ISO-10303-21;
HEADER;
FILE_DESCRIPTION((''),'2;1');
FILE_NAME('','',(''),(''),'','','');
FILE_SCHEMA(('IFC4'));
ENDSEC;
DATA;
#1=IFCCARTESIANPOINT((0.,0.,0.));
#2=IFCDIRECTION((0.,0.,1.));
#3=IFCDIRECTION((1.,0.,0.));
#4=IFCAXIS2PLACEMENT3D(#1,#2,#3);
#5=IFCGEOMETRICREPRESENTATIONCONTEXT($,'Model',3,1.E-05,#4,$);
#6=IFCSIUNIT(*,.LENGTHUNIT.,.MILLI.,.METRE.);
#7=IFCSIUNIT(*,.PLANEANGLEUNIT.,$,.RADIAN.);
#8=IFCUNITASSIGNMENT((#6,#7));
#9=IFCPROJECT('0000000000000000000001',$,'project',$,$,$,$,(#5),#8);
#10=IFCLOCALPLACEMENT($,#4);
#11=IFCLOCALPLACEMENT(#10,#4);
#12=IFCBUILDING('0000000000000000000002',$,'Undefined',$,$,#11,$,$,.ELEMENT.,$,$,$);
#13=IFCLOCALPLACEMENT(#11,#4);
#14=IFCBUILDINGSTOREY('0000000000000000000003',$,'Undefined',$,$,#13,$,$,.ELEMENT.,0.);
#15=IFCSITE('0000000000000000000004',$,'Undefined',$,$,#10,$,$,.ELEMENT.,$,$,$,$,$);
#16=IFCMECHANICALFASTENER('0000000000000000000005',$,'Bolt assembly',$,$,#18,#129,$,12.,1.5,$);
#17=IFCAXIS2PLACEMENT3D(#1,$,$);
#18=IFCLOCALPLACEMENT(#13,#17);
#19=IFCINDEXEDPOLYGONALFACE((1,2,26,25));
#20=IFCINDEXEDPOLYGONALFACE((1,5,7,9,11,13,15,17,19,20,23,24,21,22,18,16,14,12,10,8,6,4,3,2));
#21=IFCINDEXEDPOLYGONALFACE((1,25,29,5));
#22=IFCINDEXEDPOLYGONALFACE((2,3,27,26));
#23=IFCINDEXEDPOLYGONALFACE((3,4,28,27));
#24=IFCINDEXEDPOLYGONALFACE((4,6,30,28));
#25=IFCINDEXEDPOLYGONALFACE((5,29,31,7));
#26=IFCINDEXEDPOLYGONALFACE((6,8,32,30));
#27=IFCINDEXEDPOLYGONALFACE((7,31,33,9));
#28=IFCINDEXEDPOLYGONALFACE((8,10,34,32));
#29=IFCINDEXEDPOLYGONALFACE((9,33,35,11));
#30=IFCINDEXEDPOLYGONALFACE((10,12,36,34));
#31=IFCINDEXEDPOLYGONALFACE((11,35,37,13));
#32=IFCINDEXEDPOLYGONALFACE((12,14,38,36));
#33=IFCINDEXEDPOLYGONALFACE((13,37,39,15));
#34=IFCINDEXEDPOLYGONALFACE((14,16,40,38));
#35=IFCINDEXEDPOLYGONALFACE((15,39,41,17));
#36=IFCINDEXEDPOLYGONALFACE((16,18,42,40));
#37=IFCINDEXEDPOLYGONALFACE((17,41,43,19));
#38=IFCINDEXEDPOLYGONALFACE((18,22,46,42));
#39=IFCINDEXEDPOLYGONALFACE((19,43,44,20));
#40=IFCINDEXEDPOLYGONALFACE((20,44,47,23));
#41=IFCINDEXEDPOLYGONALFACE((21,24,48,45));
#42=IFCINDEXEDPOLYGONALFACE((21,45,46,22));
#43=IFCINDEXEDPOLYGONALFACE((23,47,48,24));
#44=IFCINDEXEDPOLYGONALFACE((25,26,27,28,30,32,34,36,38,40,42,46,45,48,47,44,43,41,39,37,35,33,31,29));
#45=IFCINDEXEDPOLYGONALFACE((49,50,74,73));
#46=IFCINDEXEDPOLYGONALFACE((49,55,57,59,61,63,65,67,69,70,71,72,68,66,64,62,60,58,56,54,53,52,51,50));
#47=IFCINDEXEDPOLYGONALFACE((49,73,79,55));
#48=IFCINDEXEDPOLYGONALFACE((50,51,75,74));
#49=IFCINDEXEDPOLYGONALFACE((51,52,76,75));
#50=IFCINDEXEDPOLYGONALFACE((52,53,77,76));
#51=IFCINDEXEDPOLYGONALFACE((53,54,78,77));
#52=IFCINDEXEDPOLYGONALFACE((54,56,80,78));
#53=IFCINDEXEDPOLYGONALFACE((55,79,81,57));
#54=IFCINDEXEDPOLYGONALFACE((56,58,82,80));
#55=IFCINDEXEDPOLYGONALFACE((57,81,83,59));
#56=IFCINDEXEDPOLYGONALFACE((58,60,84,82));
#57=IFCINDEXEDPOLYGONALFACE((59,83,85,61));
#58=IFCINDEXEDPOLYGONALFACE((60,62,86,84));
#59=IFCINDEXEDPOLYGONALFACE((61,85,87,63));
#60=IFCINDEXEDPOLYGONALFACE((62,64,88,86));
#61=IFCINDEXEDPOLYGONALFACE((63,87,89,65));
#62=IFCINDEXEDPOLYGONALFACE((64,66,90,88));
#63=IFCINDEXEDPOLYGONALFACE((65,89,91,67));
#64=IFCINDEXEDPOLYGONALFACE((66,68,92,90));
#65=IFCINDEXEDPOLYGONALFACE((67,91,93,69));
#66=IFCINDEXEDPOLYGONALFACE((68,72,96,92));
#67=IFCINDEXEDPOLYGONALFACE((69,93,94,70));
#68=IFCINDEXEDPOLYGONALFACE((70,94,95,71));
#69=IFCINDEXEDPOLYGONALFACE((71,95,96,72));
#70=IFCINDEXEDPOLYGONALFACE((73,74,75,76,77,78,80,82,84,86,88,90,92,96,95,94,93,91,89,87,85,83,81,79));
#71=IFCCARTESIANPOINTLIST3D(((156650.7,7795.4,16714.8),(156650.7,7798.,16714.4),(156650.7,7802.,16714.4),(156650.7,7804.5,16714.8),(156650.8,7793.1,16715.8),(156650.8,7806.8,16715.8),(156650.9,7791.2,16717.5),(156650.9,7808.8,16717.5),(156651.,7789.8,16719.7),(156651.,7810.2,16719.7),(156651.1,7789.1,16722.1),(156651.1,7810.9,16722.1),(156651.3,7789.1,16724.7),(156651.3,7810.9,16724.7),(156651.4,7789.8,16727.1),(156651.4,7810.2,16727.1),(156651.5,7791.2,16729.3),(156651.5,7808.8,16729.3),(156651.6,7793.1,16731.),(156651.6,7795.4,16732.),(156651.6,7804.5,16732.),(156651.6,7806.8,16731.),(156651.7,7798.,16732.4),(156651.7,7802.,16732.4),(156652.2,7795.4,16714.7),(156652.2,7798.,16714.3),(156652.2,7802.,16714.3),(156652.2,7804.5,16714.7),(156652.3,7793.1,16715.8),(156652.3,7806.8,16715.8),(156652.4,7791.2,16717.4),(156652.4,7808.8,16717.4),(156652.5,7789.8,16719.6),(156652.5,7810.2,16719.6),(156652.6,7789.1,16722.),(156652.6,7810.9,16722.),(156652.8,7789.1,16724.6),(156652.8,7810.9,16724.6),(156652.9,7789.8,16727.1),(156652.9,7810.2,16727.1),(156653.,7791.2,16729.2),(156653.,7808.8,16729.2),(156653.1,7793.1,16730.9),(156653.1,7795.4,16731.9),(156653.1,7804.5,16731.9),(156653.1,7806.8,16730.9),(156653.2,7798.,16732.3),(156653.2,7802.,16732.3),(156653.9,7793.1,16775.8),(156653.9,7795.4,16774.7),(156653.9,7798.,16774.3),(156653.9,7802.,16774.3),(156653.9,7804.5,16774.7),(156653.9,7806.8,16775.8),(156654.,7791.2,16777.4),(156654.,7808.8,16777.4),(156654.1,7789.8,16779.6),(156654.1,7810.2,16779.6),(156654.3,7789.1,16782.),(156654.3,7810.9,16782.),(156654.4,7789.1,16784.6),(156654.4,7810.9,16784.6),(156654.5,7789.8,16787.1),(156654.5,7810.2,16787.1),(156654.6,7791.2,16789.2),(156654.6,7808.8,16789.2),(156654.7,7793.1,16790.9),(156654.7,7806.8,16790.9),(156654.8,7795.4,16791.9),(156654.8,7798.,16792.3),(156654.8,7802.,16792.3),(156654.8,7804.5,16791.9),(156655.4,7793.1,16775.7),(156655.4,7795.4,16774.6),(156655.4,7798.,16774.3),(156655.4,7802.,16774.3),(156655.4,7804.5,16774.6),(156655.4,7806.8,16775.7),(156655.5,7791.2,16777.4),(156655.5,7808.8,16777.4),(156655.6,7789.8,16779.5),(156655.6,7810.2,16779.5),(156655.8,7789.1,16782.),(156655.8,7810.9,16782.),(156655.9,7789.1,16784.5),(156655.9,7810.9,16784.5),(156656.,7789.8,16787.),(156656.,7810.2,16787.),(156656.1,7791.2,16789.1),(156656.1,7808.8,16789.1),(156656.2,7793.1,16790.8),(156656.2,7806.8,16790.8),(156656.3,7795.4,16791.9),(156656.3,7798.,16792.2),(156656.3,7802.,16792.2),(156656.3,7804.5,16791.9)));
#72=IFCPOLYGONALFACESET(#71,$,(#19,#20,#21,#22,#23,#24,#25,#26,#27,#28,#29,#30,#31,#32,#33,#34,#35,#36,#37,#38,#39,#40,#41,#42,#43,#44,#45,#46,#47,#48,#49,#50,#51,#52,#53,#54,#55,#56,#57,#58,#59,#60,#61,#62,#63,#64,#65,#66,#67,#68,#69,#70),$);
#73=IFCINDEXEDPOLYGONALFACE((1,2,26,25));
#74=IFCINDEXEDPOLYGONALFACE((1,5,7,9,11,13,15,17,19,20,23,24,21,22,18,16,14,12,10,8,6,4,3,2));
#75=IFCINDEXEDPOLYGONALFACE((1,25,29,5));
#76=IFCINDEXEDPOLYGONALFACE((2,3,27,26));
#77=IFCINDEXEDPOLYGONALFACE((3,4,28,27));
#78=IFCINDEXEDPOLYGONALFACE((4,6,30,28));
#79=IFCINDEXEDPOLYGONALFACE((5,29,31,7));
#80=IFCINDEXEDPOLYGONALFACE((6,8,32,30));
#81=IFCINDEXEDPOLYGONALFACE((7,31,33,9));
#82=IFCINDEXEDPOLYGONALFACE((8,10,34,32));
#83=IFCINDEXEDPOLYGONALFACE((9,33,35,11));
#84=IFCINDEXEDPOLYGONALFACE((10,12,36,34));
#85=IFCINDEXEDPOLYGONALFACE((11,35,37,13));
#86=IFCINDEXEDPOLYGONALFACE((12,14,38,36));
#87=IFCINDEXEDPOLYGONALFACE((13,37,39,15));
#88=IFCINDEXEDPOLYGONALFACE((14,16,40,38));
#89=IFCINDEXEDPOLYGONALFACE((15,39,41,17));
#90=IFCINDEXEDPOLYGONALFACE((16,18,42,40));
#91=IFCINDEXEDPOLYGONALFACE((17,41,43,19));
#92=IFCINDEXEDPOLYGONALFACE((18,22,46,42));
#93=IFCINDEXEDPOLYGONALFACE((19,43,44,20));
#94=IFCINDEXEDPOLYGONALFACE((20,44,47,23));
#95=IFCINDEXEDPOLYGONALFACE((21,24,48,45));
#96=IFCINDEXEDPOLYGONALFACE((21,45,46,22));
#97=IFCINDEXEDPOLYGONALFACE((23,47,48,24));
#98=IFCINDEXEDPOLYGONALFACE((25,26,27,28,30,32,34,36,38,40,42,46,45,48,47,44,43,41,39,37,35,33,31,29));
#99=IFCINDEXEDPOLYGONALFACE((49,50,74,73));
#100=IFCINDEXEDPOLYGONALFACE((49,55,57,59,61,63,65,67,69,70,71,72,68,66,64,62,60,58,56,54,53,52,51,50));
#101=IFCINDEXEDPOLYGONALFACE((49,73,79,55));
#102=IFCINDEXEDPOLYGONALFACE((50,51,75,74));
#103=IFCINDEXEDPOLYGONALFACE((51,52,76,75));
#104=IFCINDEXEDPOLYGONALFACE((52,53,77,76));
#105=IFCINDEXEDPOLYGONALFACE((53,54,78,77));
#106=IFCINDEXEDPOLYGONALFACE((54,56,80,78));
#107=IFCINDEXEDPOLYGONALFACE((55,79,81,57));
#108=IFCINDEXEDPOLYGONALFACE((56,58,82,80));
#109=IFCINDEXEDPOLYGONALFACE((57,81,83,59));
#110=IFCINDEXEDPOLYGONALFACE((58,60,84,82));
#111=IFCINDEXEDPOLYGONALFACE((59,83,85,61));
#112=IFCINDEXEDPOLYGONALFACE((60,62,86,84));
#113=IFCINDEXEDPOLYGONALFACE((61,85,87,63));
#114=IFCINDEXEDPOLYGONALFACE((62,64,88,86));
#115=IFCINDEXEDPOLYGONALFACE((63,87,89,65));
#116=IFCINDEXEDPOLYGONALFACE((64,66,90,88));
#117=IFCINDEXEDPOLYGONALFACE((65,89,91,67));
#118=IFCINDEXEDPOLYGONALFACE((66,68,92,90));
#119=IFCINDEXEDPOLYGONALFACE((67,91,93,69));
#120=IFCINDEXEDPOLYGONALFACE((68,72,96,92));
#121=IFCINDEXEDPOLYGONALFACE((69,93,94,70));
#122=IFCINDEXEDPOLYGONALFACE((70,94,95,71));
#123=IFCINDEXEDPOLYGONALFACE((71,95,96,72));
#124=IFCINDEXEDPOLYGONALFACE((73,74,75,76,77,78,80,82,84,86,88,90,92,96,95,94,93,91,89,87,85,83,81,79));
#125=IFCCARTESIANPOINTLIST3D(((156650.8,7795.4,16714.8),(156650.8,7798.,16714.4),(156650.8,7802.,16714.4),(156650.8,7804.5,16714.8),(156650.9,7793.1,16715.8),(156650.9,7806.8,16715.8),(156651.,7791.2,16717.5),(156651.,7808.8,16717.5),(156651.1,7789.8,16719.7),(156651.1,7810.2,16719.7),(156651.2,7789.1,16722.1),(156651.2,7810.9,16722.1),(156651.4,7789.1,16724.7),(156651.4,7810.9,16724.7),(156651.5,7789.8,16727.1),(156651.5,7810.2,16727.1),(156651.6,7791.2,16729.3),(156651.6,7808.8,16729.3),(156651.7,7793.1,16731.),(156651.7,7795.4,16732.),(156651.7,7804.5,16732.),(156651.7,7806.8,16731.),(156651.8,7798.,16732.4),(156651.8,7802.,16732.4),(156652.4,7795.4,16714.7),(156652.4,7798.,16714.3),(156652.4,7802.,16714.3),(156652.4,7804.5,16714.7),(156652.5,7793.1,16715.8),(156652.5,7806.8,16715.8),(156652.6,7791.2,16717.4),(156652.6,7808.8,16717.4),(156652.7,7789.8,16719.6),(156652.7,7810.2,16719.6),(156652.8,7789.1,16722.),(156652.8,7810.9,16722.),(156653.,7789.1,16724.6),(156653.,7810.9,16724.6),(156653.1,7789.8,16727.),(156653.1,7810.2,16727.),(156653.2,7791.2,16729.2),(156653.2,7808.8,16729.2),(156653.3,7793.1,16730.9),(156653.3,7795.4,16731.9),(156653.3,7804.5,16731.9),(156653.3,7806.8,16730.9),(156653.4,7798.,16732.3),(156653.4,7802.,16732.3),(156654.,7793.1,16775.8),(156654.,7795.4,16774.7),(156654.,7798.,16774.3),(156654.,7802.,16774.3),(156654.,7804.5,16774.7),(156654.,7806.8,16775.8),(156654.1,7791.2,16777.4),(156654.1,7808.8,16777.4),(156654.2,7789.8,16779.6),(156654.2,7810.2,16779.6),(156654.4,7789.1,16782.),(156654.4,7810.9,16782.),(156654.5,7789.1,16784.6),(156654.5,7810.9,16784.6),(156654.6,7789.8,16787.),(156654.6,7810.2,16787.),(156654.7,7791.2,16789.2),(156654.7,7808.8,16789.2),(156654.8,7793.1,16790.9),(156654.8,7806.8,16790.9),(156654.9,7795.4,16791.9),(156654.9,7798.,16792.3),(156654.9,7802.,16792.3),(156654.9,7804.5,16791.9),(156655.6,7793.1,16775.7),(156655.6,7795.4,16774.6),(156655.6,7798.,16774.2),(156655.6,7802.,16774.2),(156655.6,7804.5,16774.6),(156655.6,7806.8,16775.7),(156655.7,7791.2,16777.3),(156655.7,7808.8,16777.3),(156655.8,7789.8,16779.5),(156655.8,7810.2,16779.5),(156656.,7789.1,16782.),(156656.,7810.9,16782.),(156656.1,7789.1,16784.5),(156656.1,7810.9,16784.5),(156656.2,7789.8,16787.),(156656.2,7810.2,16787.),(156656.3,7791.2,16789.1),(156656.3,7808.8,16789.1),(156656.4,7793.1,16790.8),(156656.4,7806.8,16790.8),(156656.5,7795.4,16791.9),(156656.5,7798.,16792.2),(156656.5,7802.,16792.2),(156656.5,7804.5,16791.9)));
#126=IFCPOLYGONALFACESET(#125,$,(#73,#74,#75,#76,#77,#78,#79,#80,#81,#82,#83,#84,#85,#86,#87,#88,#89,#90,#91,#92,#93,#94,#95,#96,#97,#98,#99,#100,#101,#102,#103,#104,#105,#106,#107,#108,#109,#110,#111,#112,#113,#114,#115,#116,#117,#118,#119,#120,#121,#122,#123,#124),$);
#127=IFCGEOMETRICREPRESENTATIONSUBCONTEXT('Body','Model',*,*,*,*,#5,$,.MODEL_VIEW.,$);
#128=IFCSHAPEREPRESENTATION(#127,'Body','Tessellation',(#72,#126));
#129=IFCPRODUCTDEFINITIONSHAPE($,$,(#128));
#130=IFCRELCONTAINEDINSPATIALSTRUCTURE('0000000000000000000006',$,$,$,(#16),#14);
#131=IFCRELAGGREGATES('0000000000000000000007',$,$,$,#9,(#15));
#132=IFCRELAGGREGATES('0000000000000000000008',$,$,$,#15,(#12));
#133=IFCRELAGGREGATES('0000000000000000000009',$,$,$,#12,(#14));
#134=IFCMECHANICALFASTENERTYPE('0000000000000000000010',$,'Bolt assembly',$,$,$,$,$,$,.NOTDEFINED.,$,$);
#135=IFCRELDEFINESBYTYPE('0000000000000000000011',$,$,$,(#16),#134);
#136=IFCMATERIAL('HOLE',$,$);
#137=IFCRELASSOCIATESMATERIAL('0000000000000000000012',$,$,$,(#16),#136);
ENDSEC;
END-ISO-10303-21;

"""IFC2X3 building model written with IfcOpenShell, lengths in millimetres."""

from ifc_helpers import new_model, entity, si_unit, frame, origin_with_axes, place, context, subcontext, project, spatial, source, transform, mapped, material, type_object, element, save


model = new_model("IFC2X3")

# Units and contexts
model_context = context("Model", 3, precision=1e-05, world=origin_with_axes())
body_context = subcontext(model_context, "Body", "Model", "MODEL_VIEW")
ifc_project = project(units=[si_unit("LENGTHUNIT", "METRE", prefix="MILLI"), si_unit("PLANEANGLEUNIT", "RADIAN")], contexts=[model_context])

# Site, building, storey
site_placement = place(None, origin_with_axes())
site = spatial("IfcSite", under=ifc_project, at=site_placement, Name="Undefined", CompositionType="ELEMENT")
building_placement = place(site_placement, origin_with_axes())
building = spatial("IfcBuilding", under=site, at=building_placement, Name="Undefined", CompositionType="ELEMENT")
storey_placement = place(building_placement, origin_with_axes())
storey = spatial("IfcBuildingStorey", under=building, at=storey_placement, Name="Undefined", CompositionType="ELEMENT", Elevation=0.0)

# Mechanical fastener
ifc_material_1 = material(Name="HOLE")
mechanical_fastener_type = type_object("IfcMechanicalFastenerType", Name="Bolt assembly")
shared_circle_1 = entity("IfcCircle", entity("IfcAxis2Placement2D", entity("IfcCartesianPoint", [0.0, -2.0]), entity("IfcDirection", [1.0, 0.0])), 9.0)
shared_circle_2 = entity("IfcCircle", entity("IfcAxis2Placement2D", entity("IfcCartesianPoint", [0.0, 2.0]), entity("IfcDirection", [-1.0, 0.0])), 9.0)
shared_composite_curve = entity("IfcCompositeCurve", [entity("IfcCompositeCurveSegment", "CONTINUOUS", True, entity("IfcPolyline", [entity("IfcCartesianPoint", [9.0, 2.0]), entity("IfcCartesianPoint", [9.0, -2.0])])), entity("IfcCompositeCurveSegment", "CONTINUOUS", True, entity("IfcTrimmedCurve", shared_circle_1, [entity("IfcParameterValue", 0.0)], [entity("IfcParameterValue", 3.141593)], False, "PARAMETER")), entity("IfcCompositeCurveSegment", "CONTINUOUS", True, entity("IfcPolyline", [entity("IfcCartesianPoint", [-9.0, -2.0]), entity("IfcCartesianPoint", [-9.0, 2.0])])), entity("IfcCompositeCurveSegment", "DISCONTINUOUS", True, entity("IfcTrimmedCurve", shared_circle_2, [entity("IfcParameterValue", 0.0)], [entity("IfcParameterValue", 3.141593)], False, "PARAMETER"))], False)
shared_shape_1 = source(origin_with_axes(), body_context, "Body", "SweptSolid", [
    entity("IfcExtrudedAreaSolid", entity("IfcArbitraryClosedProfileDef", "AREA", None, shared_composite_curve), entity("IfcAxis2Placement3D", entity("IfcCartesianPoint", [0.0, 0.1, 0.0]), entity("IfcDirection", [0.0, 1.0, 0.0]), entity("IfcDirection", [1.0, 0.0, 0.0])), entity("IfcDirection", [0.0, 0.0, 1.0]), 1.5),
    entity("IfcExtrudedAreaSolid", entity("IfcArbitraryClosedProfileDef", "AREA", None, shared_composite_curve), entity("IfcAxis2Placement3D", entity("IfcCartesianPoint", [0.0, -0.1, 0.0]), entity("IfcDirection", [0.0, 1.0, 0.0]), entity("IfcDirection", [1.0, 0.0, 0.0])), entity("IfcDirection", [0.0, 0.0, 1.0]), 1.6),
])
mechanical_fastener_1_placement = place(storey_placement, frame((156655.9, 7800.0, 16783.2), z_axis=(0.0, 1.0, 0.0), x_axis=(-0.052392, 0.0, -0.998627)))
element("IfcMechanicalFastener", 1, at=mechanical_fastener_1_placement, inside=storey, type_object=mechanical_fastener_type, material=ifc_material_1, Name="Bolt assembly", NominalDiameter=12.0, NominalLength=1.5, context=body_context, shape_type="MappedRepresentation", body=[
    mapped(shared_shape_1, transform((0.0, 0.0, 0.0))),
    mapped(shared_shape_1, transform((60.0, 0.0, 0.0))),
])

save(model, "model.ifc")
